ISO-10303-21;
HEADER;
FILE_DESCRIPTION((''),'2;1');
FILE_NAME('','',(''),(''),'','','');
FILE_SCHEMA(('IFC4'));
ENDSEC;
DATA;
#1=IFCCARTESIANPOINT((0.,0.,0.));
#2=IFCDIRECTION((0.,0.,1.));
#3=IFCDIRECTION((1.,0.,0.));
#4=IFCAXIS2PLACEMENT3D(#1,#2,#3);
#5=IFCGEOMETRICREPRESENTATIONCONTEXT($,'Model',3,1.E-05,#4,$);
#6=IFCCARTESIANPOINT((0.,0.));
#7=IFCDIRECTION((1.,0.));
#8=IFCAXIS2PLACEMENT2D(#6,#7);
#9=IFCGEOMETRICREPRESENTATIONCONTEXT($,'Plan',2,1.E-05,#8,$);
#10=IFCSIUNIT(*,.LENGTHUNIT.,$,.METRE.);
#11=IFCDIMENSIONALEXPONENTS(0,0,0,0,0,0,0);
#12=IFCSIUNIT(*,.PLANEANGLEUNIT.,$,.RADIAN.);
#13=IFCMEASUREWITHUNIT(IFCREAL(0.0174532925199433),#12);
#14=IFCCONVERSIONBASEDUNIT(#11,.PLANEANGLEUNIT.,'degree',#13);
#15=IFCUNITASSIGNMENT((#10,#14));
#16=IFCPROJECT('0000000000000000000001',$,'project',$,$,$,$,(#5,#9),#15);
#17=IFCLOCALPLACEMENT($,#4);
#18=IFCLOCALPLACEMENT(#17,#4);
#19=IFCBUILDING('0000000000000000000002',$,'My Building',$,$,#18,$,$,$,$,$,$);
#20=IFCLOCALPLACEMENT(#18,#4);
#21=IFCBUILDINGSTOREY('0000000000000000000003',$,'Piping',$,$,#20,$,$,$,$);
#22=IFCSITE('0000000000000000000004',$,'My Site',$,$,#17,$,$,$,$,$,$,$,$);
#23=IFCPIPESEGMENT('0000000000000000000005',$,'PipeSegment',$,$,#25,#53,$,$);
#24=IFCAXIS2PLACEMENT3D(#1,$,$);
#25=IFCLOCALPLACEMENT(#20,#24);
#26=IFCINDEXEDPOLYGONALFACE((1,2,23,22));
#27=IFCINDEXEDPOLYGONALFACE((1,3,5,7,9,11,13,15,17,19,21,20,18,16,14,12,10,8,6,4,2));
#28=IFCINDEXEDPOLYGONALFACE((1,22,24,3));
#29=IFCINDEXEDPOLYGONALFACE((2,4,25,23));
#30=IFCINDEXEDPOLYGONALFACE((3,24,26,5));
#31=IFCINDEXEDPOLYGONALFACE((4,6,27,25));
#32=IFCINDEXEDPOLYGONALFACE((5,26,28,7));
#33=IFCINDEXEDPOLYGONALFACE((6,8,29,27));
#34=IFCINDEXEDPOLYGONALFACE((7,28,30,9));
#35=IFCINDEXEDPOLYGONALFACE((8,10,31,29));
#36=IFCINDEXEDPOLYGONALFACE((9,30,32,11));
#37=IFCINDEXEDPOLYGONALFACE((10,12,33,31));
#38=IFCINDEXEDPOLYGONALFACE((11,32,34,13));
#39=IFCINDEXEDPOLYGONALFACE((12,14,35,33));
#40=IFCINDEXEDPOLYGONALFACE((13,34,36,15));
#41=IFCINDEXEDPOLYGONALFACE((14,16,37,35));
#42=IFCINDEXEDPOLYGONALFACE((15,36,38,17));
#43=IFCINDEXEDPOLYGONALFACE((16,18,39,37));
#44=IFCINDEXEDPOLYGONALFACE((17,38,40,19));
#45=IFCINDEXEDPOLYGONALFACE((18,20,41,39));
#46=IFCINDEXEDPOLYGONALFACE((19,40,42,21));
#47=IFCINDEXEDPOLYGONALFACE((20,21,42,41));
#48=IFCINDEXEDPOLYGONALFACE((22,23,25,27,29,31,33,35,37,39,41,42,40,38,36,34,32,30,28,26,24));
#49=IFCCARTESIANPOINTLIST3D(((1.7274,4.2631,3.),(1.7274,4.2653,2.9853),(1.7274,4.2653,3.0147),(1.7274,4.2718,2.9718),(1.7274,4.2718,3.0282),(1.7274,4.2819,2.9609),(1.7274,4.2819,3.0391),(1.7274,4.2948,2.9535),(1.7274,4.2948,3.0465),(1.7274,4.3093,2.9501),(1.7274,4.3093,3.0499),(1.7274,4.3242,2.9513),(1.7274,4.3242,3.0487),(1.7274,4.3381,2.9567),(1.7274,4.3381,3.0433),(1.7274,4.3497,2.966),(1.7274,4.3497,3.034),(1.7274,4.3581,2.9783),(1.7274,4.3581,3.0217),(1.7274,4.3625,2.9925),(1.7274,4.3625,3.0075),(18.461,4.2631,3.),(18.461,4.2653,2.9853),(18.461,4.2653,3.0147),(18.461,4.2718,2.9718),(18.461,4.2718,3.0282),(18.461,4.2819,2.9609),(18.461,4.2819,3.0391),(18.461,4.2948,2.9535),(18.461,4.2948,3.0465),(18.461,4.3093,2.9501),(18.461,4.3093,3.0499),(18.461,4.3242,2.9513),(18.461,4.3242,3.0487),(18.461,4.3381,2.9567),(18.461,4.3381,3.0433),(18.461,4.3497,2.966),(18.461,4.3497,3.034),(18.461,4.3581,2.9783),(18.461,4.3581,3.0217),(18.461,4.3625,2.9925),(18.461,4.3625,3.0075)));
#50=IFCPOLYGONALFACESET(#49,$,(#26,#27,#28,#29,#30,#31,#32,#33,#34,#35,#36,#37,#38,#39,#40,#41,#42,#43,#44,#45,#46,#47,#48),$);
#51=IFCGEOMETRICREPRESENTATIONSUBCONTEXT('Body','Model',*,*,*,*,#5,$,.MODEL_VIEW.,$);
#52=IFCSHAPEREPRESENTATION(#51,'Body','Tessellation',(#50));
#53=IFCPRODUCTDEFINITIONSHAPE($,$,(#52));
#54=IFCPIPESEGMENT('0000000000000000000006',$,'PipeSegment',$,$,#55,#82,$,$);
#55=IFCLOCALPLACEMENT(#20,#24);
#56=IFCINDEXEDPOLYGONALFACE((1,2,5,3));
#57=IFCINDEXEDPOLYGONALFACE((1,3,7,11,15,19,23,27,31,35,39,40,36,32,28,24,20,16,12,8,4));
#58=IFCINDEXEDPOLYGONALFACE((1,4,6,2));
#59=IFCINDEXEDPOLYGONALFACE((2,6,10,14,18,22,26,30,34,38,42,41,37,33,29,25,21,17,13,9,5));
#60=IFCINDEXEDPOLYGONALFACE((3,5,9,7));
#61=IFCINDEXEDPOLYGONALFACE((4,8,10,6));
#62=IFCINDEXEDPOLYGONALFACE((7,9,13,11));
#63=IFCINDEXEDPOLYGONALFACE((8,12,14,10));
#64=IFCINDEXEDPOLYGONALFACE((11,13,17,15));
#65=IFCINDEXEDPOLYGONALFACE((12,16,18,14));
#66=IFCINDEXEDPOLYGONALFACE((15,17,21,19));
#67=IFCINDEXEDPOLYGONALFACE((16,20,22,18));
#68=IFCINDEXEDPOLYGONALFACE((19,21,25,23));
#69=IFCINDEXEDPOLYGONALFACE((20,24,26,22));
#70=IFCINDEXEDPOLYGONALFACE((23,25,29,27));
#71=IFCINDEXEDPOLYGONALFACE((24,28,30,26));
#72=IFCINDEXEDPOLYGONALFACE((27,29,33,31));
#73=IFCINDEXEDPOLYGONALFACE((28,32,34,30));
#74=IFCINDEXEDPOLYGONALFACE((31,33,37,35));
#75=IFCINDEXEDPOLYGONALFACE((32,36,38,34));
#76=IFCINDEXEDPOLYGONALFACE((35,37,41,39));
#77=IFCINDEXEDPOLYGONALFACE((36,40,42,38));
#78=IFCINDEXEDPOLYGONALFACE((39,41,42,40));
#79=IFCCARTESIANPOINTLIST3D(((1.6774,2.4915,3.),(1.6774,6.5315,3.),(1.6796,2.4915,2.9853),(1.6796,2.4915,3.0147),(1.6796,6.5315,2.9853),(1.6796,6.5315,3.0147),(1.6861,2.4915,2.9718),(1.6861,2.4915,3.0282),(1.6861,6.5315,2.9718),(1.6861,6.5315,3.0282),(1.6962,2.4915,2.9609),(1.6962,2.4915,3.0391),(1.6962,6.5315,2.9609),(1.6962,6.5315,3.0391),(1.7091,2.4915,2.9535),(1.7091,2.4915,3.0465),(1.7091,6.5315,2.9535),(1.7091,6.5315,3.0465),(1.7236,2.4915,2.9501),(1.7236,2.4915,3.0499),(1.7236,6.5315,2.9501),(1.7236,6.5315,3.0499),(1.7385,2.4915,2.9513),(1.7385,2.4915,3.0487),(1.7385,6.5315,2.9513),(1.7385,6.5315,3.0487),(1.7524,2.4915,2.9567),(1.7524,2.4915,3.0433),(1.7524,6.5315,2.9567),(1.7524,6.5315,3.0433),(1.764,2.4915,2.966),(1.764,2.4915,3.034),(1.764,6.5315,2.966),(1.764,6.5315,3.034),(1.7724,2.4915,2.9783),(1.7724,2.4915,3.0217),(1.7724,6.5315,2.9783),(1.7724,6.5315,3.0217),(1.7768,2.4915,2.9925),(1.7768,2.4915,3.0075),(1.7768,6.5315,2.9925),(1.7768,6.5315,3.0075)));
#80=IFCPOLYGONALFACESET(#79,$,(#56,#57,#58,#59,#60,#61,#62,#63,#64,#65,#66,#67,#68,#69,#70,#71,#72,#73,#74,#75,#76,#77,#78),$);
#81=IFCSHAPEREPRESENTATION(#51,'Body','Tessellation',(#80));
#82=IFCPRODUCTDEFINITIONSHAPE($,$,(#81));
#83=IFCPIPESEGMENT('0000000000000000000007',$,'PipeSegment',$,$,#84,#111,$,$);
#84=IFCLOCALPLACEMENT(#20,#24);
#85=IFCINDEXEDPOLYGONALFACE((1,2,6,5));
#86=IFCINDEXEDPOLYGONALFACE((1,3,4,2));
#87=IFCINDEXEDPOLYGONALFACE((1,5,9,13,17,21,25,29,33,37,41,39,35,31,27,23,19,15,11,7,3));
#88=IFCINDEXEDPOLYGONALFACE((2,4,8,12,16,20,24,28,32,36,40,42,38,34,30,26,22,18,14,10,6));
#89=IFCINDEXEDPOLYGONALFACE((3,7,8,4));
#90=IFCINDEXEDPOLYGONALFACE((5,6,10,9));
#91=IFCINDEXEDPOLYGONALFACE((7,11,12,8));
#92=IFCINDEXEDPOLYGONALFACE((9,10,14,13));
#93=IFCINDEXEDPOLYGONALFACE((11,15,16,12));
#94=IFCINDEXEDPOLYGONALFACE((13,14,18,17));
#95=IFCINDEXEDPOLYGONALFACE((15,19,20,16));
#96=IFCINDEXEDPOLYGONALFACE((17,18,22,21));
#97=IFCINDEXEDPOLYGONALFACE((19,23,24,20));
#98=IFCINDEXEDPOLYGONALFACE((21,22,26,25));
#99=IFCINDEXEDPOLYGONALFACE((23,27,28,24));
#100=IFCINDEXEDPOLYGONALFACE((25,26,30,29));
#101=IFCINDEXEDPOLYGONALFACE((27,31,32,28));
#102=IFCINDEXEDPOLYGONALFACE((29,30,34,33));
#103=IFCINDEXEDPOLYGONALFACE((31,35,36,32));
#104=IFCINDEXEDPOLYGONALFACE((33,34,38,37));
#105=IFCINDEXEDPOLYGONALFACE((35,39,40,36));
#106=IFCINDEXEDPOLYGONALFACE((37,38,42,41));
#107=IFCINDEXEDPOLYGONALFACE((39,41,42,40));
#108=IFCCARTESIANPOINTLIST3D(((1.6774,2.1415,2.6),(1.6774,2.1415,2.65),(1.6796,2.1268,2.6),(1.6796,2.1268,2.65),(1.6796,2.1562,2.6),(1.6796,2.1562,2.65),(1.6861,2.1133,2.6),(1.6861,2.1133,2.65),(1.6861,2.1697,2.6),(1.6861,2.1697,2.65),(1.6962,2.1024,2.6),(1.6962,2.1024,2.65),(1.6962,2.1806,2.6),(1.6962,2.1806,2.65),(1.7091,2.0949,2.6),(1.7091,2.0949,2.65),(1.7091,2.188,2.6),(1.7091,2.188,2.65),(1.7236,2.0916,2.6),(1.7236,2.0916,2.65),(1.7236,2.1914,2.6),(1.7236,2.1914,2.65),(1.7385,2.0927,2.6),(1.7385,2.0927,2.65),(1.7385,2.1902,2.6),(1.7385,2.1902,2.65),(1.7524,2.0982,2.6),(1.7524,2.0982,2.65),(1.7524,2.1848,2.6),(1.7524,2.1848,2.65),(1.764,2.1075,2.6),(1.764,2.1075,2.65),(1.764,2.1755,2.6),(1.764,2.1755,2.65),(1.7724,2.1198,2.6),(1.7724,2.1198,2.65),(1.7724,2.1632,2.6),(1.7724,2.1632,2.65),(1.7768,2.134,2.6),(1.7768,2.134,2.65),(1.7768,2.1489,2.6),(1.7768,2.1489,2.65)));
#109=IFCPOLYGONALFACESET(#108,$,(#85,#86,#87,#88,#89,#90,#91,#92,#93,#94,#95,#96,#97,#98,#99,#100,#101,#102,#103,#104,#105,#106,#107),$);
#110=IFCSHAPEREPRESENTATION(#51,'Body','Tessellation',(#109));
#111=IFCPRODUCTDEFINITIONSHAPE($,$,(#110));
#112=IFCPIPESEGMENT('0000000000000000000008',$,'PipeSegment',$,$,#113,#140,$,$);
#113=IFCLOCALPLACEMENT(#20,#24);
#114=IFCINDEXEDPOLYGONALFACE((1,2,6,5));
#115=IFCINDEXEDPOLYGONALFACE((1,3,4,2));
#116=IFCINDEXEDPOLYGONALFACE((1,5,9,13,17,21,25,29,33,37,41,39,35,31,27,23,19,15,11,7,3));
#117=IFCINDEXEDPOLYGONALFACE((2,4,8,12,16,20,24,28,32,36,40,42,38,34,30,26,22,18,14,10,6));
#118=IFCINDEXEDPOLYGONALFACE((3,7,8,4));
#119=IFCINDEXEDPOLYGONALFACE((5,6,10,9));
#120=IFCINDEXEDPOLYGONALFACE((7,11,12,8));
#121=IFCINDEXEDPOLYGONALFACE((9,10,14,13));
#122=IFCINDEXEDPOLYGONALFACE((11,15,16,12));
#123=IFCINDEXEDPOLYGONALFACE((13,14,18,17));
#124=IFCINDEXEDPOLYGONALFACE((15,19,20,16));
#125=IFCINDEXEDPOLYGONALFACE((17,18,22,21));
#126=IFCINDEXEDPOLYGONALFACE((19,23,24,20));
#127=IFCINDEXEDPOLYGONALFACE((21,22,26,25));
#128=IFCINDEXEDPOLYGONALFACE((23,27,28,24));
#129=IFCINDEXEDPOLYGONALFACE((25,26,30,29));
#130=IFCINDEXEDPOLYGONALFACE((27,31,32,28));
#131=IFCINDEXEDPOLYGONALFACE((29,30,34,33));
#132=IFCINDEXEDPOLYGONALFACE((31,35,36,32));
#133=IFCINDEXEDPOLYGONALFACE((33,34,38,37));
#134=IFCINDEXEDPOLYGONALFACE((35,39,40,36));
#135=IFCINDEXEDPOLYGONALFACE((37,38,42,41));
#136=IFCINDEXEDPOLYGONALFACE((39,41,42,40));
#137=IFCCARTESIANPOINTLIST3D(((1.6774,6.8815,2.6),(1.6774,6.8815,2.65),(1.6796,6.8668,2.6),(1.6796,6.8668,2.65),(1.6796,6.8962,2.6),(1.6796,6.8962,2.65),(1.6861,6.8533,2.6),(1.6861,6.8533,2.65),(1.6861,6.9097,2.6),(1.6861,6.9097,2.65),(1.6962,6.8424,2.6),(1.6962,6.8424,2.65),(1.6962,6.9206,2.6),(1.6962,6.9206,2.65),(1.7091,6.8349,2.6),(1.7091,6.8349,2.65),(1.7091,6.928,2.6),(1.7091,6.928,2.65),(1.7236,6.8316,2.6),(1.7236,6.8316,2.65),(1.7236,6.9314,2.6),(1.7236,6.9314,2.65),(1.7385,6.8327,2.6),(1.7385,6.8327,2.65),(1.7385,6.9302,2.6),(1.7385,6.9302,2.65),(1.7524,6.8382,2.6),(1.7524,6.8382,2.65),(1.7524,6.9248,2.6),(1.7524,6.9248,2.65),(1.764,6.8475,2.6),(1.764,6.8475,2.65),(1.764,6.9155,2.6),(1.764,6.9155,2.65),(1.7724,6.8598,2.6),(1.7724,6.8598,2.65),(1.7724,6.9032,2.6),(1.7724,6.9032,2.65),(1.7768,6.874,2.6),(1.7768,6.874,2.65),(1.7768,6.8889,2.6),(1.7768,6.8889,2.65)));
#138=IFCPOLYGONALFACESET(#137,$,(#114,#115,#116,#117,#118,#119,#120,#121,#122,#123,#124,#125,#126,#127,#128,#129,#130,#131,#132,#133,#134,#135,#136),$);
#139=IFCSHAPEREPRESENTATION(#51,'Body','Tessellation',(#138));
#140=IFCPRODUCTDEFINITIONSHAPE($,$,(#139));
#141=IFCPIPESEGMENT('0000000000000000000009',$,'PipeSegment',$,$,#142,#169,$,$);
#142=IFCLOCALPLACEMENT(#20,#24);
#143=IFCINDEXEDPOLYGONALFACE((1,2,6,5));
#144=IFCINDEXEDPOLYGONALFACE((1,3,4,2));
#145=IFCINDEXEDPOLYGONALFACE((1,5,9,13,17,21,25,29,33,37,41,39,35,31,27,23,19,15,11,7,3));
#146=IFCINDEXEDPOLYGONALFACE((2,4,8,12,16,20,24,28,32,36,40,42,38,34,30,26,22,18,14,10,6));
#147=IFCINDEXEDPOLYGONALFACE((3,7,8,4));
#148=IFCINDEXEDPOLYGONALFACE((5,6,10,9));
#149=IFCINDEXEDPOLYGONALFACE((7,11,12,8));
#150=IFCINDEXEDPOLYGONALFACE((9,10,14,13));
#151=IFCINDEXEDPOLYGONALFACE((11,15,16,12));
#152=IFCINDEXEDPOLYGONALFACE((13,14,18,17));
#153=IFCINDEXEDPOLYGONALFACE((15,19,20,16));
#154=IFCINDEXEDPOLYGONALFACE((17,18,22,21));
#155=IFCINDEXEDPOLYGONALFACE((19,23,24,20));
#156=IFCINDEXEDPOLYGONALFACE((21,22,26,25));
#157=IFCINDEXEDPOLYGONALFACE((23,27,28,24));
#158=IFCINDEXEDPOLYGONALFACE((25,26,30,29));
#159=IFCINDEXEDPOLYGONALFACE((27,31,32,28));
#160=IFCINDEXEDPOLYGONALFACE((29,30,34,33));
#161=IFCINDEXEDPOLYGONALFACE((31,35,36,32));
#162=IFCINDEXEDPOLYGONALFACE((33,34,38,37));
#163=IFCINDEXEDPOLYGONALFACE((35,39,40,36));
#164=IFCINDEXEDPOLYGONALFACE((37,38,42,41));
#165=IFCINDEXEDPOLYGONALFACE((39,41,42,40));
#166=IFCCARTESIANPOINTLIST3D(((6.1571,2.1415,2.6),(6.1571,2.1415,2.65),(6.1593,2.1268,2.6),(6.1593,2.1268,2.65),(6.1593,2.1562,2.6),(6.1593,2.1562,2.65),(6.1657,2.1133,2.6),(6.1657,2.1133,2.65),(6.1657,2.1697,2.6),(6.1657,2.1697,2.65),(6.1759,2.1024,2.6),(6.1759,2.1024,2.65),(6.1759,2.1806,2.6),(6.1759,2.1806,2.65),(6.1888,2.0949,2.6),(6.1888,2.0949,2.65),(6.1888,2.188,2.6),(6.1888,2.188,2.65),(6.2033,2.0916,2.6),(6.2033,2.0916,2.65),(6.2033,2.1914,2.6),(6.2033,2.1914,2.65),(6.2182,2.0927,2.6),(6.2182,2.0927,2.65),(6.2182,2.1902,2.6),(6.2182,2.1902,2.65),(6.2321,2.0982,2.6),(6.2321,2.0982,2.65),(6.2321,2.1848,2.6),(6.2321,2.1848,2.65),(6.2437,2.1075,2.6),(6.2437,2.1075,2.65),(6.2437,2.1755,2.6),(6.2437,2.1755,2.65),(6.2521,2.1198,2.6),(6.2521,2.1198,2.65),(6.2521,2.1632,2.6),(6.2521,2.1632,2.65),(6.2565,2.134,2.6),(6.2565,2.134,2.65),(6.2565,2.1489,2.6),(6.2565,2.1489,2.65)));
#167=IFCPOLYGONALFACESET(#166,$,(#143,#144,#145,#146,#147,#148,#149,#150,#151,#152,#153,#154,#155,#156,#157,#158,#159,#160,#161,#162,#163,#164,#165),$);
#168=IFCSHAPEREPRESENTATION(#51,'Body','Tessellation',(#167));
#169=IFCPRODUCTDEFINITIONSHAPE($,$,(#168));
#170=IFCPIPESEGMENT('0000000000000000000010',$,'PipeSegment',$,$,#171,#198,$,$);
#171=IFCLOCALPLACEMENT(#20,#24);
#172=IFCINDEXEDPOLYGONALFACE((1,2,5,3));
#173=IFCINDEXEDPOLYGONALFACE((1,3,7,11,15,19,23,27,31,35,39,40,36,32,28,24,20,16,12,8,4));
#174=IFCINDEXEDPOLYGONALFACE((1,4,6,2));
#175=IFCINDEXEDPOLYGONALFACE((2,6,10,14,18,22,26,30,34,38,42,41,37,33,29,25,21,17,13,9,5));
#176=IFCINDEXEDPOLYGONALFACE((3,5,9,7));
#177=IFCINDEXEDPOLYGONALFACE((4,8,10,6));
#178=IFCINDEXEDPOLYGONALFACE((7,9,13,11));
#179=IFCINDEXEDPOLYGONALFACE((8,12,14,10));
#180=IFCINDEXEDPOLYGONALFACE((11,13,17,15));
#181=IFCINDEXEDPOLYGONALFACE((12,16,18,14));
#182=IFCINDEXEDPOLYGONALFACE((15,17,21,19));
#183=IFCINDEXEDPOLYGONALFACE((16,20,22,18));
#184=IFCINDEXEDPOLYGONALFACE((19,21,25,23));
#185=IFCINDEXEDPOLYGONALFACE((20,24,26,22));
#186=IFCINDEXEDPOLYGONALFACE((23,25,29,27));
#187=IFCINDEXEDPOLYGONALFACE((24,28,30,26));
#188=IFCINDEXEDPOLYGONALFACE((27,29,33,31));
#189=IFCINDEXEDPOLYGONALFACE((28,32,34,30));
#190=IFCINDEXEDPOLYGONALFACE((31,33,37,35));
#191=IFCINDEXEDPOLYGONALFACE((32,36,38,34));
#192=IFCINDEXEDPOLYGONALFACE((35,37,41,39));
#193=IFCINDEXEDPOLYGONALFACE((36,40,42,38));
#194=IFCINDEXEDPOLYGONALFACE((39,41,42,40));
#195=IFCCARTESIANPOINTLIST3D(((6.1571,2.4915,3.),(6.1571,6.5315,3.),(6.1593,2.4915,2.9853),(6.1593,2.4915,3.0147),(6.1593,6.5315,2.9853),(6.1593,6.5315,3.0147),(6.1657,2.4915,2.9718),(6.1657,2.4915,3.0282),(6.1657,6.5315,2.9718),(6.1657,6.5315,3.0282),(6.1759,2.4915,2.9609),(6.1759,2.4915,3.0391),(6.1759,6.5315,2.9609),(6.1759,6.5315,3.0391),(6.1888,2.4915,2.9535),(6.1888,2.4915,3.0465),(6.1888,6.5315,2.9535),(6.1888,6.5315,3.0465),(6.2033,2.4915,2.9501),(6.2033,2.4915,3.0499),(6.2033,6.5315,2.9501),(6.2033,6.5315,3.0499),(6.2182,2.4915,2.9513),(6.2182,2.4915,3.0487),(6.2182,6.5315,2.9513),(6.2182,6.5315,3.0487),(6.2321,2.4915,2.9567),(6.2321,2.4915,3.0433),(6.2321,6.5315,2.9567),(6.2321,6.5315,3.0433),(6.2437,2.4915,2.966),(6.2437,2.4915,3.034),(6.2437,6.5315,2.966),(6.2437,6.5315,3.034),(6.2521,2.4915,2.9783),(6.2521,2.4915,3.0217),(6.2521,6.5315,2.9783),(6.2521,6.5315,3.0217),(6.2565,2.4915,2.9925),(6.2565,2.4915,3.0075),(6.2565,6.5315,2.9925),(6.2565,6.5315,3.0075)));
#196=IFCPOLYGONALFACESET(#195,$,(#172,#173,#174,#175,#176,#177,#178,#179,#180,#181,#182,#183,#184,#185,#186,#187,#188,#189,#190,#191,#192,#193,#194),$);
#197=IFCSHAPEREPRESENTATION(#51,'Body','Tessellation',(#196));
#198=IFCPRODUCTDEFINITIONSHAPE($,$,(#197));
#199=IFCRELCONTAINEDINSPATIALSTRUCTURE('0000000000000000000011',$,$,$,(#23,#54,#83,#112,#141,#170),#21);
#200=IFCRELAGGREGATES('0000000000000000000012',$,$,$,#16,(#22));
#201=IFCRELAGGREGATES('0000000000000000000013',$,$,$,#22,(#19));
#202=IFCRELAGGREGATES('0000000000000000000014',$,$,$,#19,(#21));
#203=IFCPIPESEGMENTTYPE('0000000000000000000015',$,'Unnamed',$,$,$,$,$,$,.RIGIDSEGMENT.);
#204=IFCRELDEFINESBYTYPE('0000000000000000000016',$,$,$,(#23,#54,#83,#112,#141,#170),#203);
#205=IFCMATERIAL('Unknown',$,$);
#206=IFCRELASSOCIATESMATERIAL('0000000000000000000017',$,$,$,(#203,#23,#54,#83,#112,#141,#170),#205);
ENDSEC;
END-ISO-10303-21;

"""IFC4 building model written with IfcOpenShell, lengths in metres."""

from ifc_helpers import new_model, entity, si_unit, converted_unit, frame, origin_with_axes, origin_2d_with_axis, place, context, subcontext, project, spatial, circle, extrude, material, material_profile, profile_set, profile_usage, type_object, element, save


model = new_model("IFC4")

# Units and contexts
model_context = context("Model", 3, precision=1e-05, world=origin_with_axes())
plan_context = context("Plan", 2, precision=1e-05, world=origin_2d_with_axis())
body_context = subcontext(model_context, "Body", "Model", "MODEL_VIEW")
ifc_project = project(units=[si_unit("LENGTHUNIT", "METRE"), converted_unit("PLANEANGLEUNIT", "degree", entity("IfcReal", 0.0174532925199433), si_unit("PLANEANGLEUNIT", "RADIAN"), dimensions=[0, 0, 0, 0, 0, 0, 0])], contexts=[model_context, plan_context])

# Site, building, storey
site_placement = place(None, origin_with_axes())
site = spatial("IfcSite", under=ifc_project, at=site_placement, Name="My Site")
building_placement = place(site_placement, origin_with_axes())
building = spatial("IfcBuilding", under=site, at=building_placement, Name="My Building")
storey_placement = place(building_placement, origin_with_axes())
storey = spatial("IfcBuildingStorey", under=building, at=storey_placement, Name="Piping")

# Pipe segments
ifc_material = material(Name="Unknown")
ifc_material_profile_1 = material_profile(ifc_material, circle(Radius=0.05))
ifc_profile_set_1 = profile_set([ifc_material_profile_1])
ifc_profile_usage_1 = profile_usage(ifc_profile_set_1, cardinal=5)
pipe_segment_type = type_object("IfcPipeSegmentType", Name="Unnamed", PredefinedType="RIGIDSEGMENT", material=ifc_profile_set_1)
pipe_segment_1_placement = place(storey_placement, frame((18.461, 4.3131, 3.0), z_axis=(-1.0, 0.0, 0.0), x_axis=(0.0, -1.0, 0.0)))
element("IfcPipeSegment", 1, at=pipe_segment_1_placement, inside=storey, type_object=pipe_segment_type, material=ifc_profile_usage_1, Name="PipeSegment", context=body_context, shape_type="SweptSolid", body=[
    extrude(circle(Radius=0.05), origin_with_axes(), (0.0, 0.0, 1.0), 16.7336),
])
ifc_profile_usage_2 = profile_usage(ifc_profile_set_1, cardinal=5)
pipe_segment_2_placement = place(storey_placement, frame((1.7274, 2.4915, 3.0), z_axis=(0.0, 1.0, 0.0), x_axis=(-1.0, 0.0, 0.0)))
element("IfcPipeSegment", 2, at=pipe_segment_2_placement, inside=storey, type_object=pipe_segment_type, material=ifc_profile_usage_2, Name="PipeSegment", context=body_context, shape_type="SweptSolid", body=[
    extrude(circle(Radius=0.05), origin_with_axes(), (0.0, 0.0, 1.0), 4.04),
])
ifc_profile_usage_3 = profile_usage(ifc_profile_set_1, cardinal=5)
pipe_segment_3_placement = place(storey_placement, frame((1.7274, 2.1415, 2.65), z_axis=(0.0, 0.0, -1.0), x_axis=(-1.0, 0.0, 0.0)))
element("IfcPipeSegment", 3, at=pipe_segment_3_placement, inside=storey, type_object=pipe_segment_type, material=ifc_profile_usage_3, Name="PipeSegment", context=body_context, shape_type="SweptSolid", body=[
    extrude(circle(Radius=0.05), origin_with_axes(), (0.0, 0.0, 1.0), 0.05),
])
ifc_profile_usage_4 = profile_usage(ifc_profile_set_1, cardinal=5)
pipe_segment_4_placement = place(storey_placement, frame((1.7274, 6.8815, 2.65), z_axis=(0.0, 0.0, -1.0), x_axis=(-1.0, 0.0, 0.0)))
element("IfcPipeSegment", 4, at=pipe_segment_4_placement, inside=storey, type_object=pipe_segment_type, material=ifc_profile_usage_4, Name="PipeSegment", context=body_context, shape_type="SweptSolid", body=[
    extrude(circle(Radius=0.05), origin_with_axes(), (0.0, 0.0, 1.0), 0.05),
])
ifc_profile_usage_5 = profile_usage(ifc_profile_set_1, cardinal=5)
pipe_segment_5_placement = place(storey_placement, frame((6.2071, 2.1415, 2.65), z_axis=(0.0, 0.0, -1.0), x_axis=(-1.0, 0.0, 0.0)))
element("IfcPipeSegment", 5, at=pipe_segment_5_placement, inside=storey, type_object=pipe_segment_type, material=ifc_profile_usage_5, Name="PipeSegment", context=body_context, shape_type="SweptSolid", body=[
    extrude(circle(Radius=0.05), origin_with_axes(), (0.0, 0.0, 1.0), 0.05),
])
ifc_profile_usage_6 = profile_usage(ifc_profile_set_1, cardinal=5)
pipe_segment_6_placement = place(storey_placement, frame((6.2071, 2.4915, 3.0), z_axis=(0.0, 1.0, 0.0), x_axis=(-1.0, 0.0, 0.0)))
element("IfcPipeSegment", 6, at=pipe_segment_6_placement, inside=storey, type_object=pipe_segment_type, material=ifc_profile_usage_6, Name="PipeSegment", context=body_context, shape_type="SweptSolid", body=[
    extrude(circle(Radius=0.05), origin_with_axes(), (0.0, 0.0, 1.0), 4.04),
])

save(model, "model.ifc")
